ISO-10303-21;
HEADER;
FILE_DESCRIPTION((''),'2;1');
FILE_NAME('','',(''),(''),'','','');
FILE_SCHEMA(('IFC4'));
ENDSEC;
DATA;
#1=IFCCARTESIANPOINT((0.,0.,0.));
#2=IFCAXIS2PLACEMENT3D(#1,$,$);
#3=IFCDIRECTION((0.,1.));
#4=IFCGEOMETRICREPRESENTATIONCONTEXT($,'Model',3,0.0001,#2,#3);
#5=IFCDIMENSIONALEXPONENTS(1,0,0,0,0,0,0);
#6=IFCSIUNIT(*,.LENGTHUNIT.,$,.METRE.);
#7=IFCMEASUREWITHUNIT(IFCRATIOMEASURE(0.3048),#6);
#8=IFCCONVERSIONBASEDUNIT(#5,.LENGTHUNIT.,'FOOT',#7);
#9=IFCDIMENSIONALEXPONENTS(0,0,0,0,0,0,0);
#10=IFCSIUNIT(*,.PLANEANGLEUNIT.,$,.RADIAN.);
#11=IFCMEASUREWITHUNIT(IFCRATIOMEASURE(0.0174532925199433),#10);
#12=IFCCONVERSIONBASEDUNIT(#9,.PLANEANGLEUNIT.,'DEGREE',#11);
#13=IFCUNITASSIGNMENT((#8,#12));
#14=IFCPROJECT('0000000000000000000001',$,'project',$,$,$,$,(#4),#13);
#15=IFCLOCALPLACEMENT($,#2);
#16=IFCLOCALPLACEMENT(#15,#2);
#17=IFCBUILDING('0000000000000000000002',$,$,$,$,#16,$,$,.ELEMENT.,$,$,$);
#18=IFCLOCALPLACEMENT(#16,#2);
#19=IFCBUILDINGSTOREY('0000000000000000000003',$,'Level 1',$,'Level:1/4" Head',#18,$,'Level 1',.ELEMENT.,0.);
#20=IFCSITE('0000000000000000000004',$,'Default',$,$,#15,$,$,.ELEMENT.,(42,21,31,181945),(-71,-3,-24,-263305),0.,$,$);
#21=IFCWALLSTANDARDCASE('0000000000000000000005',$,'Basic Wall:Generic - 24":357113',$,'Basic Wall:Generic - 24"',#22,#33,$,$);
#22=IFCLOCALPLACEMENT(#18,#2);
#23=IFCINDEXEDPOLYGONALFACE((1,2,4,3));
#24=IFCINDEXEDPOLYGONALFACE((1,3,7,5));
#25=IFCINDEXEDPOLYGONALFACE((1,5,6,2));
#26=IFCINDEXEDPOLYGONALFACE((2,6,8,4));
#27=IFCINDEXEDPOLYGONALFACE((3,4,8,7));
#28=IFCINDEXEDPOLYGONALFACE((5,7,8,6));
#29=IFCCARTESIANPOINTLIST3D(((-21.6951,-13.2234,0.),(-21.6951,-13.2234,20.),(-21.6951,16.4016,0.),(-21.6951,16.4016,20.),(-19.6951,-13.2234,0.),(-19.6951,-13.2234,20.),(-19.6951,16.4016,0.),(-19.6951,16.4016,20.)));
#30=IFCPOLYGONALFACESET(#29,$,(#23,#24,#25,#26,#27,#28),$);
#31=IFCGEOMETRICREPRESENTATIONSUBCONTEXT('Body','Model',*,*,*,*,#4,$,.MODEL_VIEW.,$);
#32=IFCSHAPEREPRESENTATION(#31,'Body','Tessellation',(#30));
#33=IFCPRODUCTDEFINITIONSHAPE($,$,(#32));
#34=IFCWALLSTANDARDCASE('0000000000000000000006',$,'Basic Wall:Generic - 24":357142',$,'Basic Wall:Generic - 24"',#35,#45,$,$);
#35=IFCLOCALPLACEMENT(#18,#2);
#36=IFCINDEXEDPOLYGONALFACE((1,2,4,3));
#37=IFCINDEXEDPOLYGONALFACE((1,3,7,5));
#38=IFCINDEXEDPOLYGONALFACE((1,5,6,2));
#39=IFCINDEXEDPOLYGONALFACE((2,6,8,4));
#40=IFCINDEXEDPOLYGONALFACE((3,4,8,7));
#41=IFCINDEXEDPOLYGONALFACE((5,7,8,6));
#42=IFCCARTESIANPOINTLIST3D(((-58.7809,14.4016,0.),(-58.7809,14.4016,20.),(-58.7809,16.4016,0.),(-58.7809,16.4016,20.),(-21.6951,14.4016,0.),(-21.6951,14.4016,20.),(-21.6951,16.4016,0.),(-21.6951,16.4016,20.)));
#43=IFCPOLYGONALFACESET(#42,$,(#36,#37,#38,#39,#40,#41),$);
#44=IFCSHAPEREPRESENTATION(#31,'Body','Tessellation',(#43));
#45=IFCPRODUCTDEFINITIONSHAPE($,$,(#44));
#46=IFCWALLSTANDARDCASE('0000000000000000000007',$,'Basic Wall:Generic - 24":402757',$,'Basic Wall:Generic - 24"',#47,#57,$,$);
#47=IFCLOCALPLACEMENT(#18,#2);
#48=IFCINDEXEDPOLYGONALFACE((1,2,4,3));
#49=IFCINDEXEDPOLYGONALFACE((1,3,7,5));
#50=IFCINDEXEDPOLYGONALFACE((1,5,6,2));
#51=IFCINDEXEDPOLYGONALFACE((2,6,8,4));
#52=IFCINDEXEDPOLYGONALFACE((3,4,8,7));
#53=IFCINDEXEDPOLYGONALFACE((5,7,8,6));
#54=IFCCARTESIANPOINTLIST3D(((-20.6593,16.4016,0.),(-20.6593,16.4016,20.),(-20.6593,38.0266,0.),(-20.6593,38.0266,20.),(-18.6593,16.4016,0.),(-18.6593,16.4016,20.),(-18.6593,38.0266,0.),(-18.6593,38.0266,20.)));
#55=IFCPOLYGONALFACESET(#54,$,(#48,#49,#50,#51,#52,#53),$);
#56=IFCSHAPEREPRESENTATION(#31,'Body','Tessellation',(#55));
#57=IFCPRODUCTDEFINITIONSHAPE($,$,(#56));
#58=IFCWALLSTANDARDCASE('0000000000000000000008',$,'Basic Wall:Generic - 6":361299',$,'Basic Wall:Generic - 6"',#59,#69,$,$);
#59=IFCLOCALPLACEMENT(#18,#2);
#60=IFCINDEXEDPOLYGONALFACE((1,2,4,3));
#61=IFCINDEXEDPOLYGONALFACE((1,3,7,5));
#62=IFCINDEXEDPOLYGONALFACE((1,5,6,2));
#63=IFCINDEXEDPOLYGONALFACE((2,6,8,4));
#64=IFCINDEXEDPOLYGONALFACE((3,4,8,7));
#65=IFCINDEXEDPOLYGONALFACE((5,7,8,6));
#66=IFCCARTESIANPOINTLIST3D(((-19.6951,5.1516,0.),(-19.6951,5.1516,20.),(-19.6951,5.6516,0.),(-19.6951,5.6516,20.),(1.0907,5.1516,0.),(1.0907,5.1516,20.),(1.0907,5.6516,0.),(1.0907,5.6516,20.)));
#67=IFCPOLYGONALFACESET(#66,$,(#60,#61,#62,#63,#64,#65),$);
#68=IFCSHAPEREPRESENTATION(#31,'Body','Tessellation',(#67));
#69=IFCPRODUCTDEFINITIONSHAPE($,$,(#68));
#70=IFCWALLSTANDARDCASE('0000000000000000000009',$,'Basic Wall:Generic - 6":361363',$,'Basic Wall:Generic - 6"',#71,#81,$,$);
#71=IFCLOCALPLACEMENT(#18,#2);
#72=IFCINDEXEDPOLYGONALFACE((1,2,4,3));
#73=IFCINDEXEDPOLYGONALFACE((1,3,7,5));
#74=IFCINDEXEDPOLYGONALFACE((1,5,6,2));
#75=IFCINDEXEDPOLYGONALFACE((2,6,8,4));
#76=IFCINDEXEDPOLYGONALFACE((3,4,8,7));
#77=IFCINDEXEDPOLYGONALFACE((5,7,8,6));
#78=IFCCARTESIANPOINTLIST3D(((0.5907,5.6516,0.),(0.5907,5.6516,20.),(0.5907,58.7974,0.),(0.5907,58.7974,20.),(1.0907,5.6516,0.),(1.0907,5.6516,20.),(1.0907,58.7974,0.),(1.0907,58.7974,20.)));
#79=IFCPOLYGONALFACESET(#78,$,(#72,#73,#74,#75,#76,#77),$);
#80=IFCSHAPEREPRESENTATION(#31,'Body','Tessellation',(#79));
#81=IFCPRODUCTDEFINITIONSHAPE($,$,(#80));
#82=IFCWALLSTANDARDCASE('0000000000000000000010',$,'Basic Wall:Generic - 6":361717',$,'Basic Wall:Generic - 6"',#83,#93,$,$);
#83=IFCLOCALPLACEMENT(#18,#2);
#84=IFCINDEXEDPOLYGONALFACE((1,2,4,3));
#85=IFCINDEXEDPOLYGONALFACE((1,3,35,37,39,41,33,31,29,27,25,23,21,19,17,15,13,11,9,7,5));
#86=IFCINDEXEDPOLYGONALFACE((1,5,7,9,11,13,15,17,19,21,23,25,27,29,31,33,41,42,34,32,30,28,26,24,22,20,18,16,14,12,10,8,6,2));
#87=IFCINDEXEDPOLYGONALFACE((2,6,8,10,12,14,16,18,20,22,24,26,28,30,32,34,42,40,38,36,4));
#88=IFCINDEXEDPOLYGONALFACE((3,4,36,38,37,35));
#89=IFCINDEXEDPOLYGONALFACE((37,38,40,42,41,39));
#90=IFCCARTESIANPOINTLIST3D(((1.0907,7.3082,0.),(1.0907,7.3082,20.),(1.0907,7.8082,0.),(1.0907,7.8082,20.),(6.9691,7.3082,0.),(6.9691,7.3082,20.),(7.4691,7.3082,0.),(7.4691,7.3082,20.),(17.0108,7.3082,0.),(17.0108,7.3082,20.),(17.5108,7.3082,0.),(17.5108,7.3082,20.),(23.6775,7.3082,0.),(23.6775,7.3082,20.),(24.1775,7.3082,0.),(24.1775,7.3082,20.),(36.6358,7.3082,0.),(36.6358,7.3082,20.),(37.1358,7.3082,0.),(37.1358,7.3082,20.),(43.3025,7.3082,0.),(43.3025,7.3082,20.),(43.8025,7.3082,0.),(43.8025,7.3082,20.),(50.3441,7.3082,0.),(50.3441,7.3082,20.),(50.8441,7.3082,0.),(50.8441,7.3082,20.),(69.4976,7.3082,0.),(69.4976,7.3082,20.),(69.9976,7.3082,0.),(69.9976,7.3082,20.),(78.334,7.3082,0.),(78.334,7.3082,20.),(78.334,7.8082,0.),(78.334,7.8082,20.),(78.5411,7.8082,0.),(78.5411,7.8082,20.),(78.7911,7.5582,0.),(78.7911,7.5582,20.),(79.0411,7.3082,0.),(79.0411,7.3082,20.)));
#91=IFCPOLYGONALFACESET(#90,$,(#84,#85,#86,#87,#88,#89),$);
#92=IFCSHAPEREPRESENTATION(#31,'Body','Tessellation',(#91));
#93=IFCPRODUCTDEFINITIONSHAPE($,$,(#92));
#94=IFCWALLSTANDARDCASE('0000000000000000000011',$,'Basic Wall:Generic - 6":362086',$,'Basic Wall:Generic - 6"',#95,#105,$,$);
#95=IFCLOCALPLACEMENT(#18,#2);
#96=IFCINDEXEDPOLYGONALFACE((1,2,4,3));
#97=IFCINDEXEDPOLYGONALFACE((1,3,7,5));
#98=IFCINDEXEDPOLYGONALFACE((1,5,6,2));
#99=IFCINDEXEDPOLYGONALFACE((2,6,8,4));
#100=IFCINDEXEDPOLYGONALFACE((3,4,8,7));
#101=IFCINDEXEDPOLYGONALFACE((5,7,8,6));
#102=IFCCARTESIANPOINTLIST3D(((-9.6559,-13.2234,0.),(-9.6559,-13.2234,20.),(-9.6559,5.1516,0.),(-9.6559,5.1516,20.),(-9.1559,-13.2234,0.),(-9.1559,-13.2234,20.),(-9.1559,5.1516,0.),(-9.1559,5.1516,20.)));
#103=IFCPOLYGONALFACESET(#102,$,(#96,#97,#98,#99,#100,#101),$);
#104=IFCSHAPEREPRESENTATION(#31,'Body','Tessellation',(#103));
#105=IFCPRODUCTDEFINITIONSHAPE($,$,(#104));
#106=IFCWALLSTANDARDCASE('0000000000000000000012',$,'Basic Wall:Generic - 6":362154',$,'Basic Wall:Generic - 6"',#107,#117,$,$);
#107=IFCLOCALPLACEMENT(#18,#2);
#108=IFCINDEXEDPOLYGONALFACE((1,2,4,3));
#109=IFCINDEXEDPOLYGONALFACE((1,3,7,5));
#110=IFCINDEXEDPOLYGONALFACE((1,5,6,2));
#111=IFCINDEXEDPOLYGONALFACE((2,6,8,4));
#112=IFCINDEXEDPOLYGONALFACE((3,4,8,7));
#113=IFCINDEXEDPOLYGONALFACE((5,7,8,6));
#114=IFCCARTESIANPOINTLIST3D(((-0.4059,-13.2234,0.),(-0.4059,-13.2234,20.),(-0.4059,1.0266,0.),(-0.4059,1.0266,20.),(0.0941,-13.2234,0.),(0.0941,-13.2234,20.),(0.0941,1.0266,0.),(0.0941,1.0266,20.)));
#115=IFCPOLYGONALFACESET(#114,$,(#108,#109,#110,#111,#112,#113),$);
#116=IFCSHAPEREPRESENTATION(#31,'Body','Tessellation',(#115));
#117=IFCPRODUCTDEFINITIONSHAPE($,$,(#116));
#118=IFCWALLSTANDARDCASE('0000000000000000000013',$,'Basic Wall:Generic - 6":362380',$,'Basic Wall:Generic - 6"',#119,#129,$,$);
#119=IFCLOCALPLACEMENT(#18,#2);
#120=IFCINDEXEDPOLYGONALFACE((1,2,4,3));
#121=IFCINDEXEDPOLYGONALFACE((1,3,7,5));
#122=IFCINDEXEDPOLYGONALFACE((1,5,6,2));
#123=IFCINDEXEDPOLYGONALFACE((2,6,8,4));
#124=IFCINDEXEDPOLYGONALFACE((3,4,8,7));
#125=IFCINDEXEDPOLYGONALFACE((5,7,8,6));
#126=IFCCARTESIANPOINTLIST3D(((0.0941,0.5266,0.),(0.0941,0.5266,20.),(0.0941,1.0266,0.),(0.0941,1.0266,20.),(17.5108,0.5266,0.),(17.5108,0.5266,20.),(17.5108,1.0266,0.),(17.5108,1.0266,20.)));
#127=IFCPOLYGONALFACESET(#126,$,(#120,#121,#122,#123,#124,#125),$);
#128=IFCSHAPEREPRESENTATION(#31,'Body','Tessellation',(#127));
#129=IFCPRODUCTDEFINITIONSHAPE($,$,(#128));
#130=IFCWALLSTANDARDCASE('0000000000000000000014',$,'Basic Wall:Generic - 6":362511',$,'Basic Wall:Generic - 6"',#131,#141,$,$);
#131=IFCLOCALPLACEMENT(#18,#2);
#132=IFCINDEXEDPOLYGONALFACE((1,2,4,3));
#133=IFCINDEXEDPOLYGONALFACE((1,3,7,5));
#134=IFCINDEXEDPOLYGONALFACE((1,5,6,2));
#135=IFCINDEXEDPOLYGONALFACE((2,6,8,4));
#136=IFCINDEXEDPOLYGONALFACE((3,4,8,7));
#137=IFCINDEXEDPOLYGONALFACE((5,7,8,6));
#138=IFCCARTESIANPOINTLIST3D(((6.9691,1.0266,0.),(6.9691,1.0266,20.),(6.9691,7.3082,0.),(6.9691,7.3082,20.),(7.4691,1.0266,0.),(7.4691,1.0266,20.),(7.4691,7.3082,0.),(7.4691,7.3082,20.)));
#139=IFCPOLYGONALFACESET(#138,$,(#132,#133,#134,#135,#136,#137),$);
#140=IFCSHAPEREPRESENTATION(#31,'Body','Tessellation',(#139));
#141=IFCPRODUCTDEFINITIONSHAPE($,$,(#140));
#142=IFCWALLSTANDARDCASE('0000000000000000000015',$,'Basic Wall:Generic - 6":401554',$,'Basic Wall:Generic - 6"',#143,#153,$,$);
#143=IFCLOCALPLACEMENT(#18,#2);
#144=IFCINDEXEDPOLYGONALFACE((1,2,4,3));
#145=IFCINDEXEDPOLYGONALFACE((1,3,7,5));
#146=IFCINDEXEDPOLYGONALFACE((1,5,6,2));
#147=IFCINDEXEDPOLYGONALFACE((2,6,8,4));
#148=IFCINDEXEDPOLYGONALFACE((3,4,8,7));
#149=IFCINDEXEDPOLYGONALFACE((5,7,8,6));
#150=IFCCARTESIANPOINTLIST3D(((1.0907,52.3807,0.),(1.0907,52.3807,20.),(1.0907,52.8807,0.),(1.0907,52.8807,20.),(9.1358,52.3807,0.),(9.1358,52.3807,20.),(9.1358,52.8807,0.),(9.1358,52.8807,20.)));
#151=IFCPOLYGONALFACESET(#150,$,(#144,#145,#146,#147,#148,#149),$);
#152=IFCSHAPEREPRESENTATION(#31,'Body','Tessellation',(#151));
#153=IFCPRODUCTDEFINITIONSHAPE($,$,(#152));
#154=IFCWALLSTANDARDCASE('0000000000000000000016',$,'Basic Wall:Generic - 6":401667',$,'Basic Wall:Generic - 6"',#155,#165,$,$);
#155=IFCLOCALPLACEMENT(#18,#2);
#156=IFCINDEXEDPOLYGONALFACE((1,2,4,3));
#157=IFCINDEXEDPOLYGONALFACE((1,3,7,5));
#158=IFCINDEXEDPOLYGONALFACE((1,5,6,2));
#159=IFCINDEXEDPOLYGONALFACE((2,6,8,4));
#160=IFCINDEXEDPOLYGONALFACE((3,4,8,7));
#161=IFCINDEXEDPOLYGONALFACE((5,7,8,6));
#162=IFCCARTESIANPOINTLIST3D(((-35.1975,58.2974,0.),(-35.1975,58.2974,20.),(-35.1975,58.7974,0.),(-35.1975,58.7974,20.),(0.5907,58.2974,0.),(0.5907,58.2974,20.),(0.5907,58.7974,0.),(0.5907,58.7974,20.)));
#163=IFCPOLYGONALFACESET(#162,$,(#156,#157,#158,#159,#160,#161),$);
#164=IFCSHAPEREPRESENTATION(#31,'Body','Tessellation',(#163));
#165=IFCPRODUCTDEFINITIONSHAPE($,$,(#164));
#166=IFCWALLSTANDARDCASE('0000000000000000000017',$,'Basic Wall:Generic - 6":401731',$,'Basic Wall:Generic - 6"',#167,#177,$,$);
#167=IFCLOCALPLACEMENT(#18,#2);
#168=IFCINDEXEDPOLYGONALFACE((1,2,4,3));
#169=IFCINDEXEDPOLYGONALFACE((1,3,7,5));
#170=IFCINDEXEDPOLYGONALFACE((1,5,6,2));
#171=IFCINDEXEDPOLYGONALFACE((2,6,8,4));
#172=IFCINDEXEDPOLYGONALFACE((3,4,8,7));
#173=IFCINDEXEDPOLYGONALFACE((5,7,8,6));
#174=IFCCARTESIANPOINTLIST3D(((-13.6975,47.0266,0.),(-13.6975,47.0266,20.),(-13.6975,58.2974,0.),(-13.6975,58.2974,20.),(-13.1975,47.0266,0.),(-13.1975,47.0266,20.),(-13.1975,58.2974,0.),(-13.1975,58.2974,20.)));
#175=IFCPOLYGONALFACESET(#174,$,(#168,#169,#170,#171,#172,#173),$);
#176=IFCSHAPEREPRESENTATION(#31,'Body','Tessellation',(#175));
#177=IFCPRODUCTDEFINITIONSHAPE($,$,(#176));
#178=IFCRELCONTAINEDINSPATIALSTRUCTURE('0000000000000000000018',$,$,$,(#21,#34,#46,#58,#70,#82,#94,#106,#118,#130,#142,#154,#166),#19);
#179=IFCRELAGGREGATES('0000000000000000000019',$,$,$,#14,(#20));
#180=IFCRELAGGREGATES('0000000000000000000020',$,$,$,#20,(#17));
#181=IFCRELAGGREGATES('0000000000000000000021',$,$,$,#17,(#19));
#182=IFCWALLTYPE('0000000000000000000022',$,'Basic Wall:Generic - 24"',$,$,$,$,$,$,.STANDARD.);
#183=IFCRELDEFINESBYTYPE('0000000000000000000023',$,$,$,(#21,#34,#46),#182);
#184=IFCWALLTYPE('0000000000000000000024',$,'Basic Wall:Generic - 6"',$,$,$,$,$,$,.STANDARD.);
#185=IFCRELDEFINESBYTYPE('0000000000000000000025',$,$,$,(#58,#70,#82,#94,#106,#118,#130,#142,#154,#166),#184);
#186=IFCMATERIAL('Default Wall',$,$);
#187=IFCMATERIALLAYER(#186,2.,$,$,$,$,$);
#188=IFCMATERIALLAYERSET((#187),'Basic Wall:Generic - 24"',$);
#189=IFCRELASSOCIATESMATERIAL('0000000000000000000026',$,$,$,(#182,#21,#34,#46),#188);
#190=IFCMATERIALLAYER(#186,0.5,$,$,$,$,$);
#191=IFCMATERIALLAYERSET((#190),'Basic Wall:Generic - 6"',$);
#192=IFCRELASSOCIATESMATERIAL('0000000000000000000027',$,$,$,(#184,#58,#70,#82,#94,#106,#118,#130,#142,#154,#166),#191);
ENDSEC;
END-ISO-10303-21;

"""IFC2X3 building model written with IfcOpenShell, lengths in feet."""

from ifc_helpers import new_model, entity, si_unit, converted_unit, direction, frame, frame_2d, origin, place, context, subcontext, project, spatial, polyline, rectangle, outline, extrude, material, layer, layer_set, layer_usage, type_object, element, save


model = new_model("IFC2X3")

# Units and contexts
model_context = context("Model", 3, precision=0.0001, world=origin(), true_north=direction((0.0, 1.0)))
body_context = subcontext(model_context, "Body", "Model", "MODEL_VIEW")
ifc_project = project(units=[converted_unit("LENGTHUNIT", "FOOT", entity("IfcRatioMeasure", 0.3048), si_unit("LENGTHUNIT", "METRE"), dimensions=[1, 0, 0, 0, 0, 0, 0]), converted_unit("PLANEANGLEUNIT", "DEGREE", entity("IfcRatioMeasure", 0.0174532925199433), si_unit("PLANEANGLEUNIT", "RADIAN"), dimensions=[0, 0, 0, 0, 0, 0, 0])], contexts=[model_context])

# Site, building, storey
site_placement = place(None, origin())
site = spatial("IfcSite", under=ifc_project, at=site_placement, Name="Default", CompositionType="ELEMENT", RefLatitude=(42, 21, 31, 181945), RefLongitude=(-71, -3, -24, -263305), RefElevation=0.0)
building_placement = place(site_placement, origin())
building = spatial("IfcBuilding", under=site, at=building_placement, CompositionType="ELEMENT")
storey_placement = place(building_placement, origin())
storey = spatial("IfcBuildingStorey", under=building, at=storey_placement, Name="Level 1", ObjectType="Level:1/4\" Head", LongName="Level 1", CompositionType="ELEMENT", Elevation=0.0)

# Walls
ifc_material = material(Name="Default Wall")
ifc_layer_1 = layer(ifc_material, 2.0)
ifc_layer_set_1 = layer_set([ifc_layer_1], Name="Basic Wall:Generic - 24\"")
ifc_layer_usage_1 = layer_usage(ifc_layer_set_1, "AXIS2", "NEGATIVE", 1.0)
wall_type_1 = type_object("IfcWallType", Name="Basic Wall:Generic - 24\"", PredefinedType="STANDARD", material=ifc_layer_set_1)
wall_1_placement = place(storey_placement, frame((-20.6951, -13.2234, 0.0), z_axis=(0.0, 0.0, 1.0), x_axis=(0.0, 1.0, 0.0)))
element("IfcWallStandardCase", 1, at=wall_1_placement, inside=storey, type_object=wall_type_1, material=ifc_layer_usage_1, Name="Basic Wall:Generic - 24\":357113", ObjectType="Basic Wall:Generic - 24\"", context=body_context, shape_type="SweptSolid", body=[
    extrude(rectangle(XDim=29.625, YDim=2.0, at=frame_2d((14.8125, 0.0), x_axis=(-1.0, 0.0))), origin(), (0.0, 0.0, 1.0), 20.0),
])
ifc_layer_usage_2 = layer_usage(ifc_layer_set_1, "AXIS2", "NEGATIVE", 1.0)
wall_2_placement = place(storey_placement, frame((-21.6951, 15.4016, 0.0), z_axis=(0.0, 0.0, 1.0), x_axis=(-1.0, 0.0, 0.0)))
element("IfcWallStandardCase", 2, at=wall_2_placement, inside=storey, type_object=wall_type_1, material=ifc_layer_usage_2, Name="Basic Wall:Generic - 24\":357142", ObjectType="Basic Wall:Generic - 24\"", context=body_context, shape_type="SweptSolid", body=[
    extrude(rectangle(XDim=37.0858, YDim=2.0, at=frame_2d((18.5429, 0.0), x_axis=(-1.0, 0.0))), origin(), (0.0, 0.0, 1.0), 20.0),
])
ifc_layer_usage_3 = layer_usage(ifc_layer_set_1, "AXIS2", "NEGATIVE", 1.0)
wall_3_placement = place(storey_placement, frame((-19.6593, 38.0266, 0.0), z_axis=(0.0, 0.0, 1.0), x_axis=(0.0, -1.0, 0.0)))
element("IfcWallStandardCase", 3, at=wall_3_placement, inside=storey, type_object=wall_type_1, material=ifc_layer_usage_3, Name="Basic Wall:Generic - 24\":402757", ObjectType="Basic Wall:Generic - 24\"", context=body_context, shape_type="SweptSolid", body=[
    extrude(rectangle(XDim=21.625, YDim=2.0, at=frame_2d((10.8125, 0.0), x_axis=(-1.0, 0.0))), origin(), (0.0, 0.0, 1.0), 20.0),
])
ifc_layer_2 = layer(ifc_material, 0.5)
ifc_layer_set_2 = layer_set([ifc_layer_2], Name="Basic Wall:Generic - 6\"")
ifc_layer_usage_4 = layer_usage(ifc_layer_set_2, "AXIS2", "NEGATIVE", 0.25)
wall_type_2 = type_object("IfcWallType", Name="Basic Wall:Generic - 6\"", PredefinedType="STANDARD", material=ifc_layer_set_2)
wall_4_placement = place(storey_placement, frame((-19.6951, 5.4016, 0.0)))
element("IfcWallStandardCase", 4, at=wall_4_placement, inside=storey, type_object=wall_type_2, material=ifc_layer_usage_4, Name="Basic Wall:Generic - 6\":361299", ObjectType="Basic Wall:Generic - 6\"", context=body_context, shape_type="SweptSolid", body=[
    extrude(rectangle(XDim=20.7858, YDim=0.5, at=frame_2d((10.3929, 0.0), x_axis=(-1.0, 0.0))), origin(), (0.0, 0.0, 1.0), 20.0),
])
ifc_layer_usage_5 = layer_usage(ifc_layer_set_2, "AXIS2", "NEGATIVE", 0.25)
wall_5_placement = place(storey_placement, frame((0.8407, 5.6516, 0.0), z_axis=(0.0, 0.0, 1.0), x_axis=(0.0, 1.0, 0.0)))
element("IfcWallStandardCase", 5, at=wall_5_placement, inside=storey, type_object=wall_type_2, material=ifc_layer_usage_5, Name="Basic Wall:Generic - 6\":361363", ObjectType="Basic Wall:Generic - 6\"", context=body_context, shape_type="SweptSolid", body=[
    extrude(rectangle(XDim=53.1458, YDim=0.5, at=frame_2d((26.5729, 0.0), x_axis=(-1.0, 0.0))), origin(), (0.0, 0.0, 1.0), 20.0),
])
ifc_layer_usage_6 = layer_usage(ifc_layer_set_2, "AXIS2", "NEGATIVE", 0.25)
wall_6_placement = place(storey_placement, frame((1.0907, 7.5582, 0.0)))
element("IfcWallStandardCase", 6, at=wall_6_placement, inside=storey, type_object=wall_type_2, material=ifc_layer_usage_6, Name="Basic Wall:Generic - 6\":361717", ObjectType="Basic Wall:Generic - 6\"", context=body_context, shape_type="SweptSolid", body=[
    extrude(outline(polyline([(77.9504, -0.25), (77.7004, 0.0), (77.4504, 0.25), (77.2432, 0.25), (0.0, 0.25), (0.0, -0.25), (5.8784, -0.25), (6.3784, -0.25), (15.92, -0.25), (16.42, -0.25), (22.5867, -0.25), (23.0867, -0.25), (35.545, -0.25), (36.045, -0.25), (42.2117, -0.25), (42.7117, -0.25), (49.2534, -0.25), (49.7534, -0.25), (68.4069, -0.25), (68.9069, -0.25), (77.2432, -0.25), (77.9504, -0.25)])), origin(), (0.0, 0.0, 1.0), 20.0),
])
ifc_layer_usage_7 = layer_usage(ifc_layer_set_2, "AXIS2", "NEGATIVE", 0.25)
wall_7_placement = place(storey_placement, frame((-9.4059, -13.2234, 0.0), z_axis=(0.0, 0.0, 1.0), x_axis=(0.0, 1.0, 0.0)))
element("IfcWallStandardCase", 7, at=wall_7_placement, inside=storey, type_object=wall_type_2, material=ifc_layer_usage_7, Name="Basic Wall:Generic - 6\":362086", ObjectType="Basic Wall:Generic - 6\"", context=body_context, shape_type="SweptSolid", body=[
    extrude(rectangle(XDim=18.375, YDim=0.5, at=frame_2d((9.1875, 0.0), x_axis=(-1.0, 0.0))), origin(), (0.0, 0.0, 1.0), 20.0),
])
ifc_layer_usage_8 = layer_usage(ifc_layer_set_2, "AXIS2", "NEGATIVE", 0.25)
wall_8_placement = place(storey_placement, frame((-0.1559, -13.2234, 0.0), z_axis=(0.0, 0.0, 1.0), x_axis=(0.0, 1.0, 0.0)))
element("IfcWallStandardCase", 8, at=wall_8_placement, inside=storey, type_object=wall_type_2, material=ifc_layer_usage_8, Name="Basic Wall:Generic - 6\":362154", ObjectType="Basic Wall:Generic - 6\"", context=body_context, shape_type="SweptSolid", body=[
    extrude(rectangle(XDim=14.25, YDim=0.5, at=frame_2d((7.125, 0.0), x_axis=(-1.0, 0.0))), origin(), (0.0, 0.0, 1.0), 20.0),
])
ifc_layer_usage_9 = layer_usage(ifc_layer_set_2, "AXIS2", "NEGATIVE", 0.25)
wall_9_placement = place(storey_placement, frame((0.0941, 0.7766, 0.0)))
element("IfcWallStandardCase", 9, at=wall_9_placement, inside=storey, type_object=wall_type_2, material=ifc_layer_usage_9, Name="Basic Wall:Generic - 6\":362380", ObjectType="Basic Wall:Generic - 6\"", context=body_context, shape_type="SweptSolid", body=[
    extrude(rectangle(XDim=17.4167, YDim=0.5, at=frame_2d((8.7083, 0.0), x_axis=(-1.0, 0.0))), origin(), (0.0, 0.0, 1.0), 20.0),
])
ifc_layer_usage_10 = layer_usage(ifc_layer_set_2, "AXIS2", "NEGATIVE", 0.25)
wall_10_placement = place(storey_placement, frame((7.2191, 1.0266, 0.0), z_axis=(0.0, 0.0, 1.0), x_axis=(0.0, 1.0, 0.0)))
element("IfcWallStandardCase", 10, at=wall_10_placement, inside=storey, type_object=wall_type_2, material=ifc_layer_usage_10, Name="Basic Wall:Generic - 6\":362511", ObjectType="Basic Wall:Generic - 6\"", context=body_context, shape_type="SweptSolid", body=[
    extrude(rectangle(XDim=6.2816, YDim=0.5, at=frame_2d((3.1408, 0.0), x_axis=(-1.0, 0.0))), origin(), (0.0, 0.0, 1.0), 20.0),
])
ifc_layer_usage_11 = layer_usage(ifc_layer_set_2, "AXIS2", "NEGATIVE", 0.25)
wall_11_placement = place(storey_placement, frame((1.0907, 52.6307, 0.0)))
element("IfcWallStandardCase", 11, at=wall_11_placement, inside=storey, type_object=wall_type_2, material=ifc_layer_usage_11, Name="Basic Wall:Generic - 6\":401554", ObjectType="Basic Wall:Generic - 6\"", context=body_context, shape_type="SweptSolid", body=[
    extrude(rectangle(XDim=8.045, YDim=0.5, at=frame_2d((4.0225, 0.0), x_axis=(-1.0, 0.0))), origin(), (0.0, 0.0, 1.0), 20.0),
])
ifc_layer_usage_12 = layer_usage(ifc_layer_set_2, "AXIS2", "NEGATIVE", 0.25)
wall_12_placement = place(storey_placement, frame((0.5907, 58.5474, 0.0), z_axis=(0.0, 0.0, 1.0), x_axis=(-1.0, 0.0, 0.0)))
element("IfcWallStandardCase", 12, at=wall_12_placement, inside=storey, type_object=wall_type_2, material=ifc_layer_usage_12, Name="Basic Wall:Generic - 6\":401667", ObjectType="Basic Wall:Generic - 6\"", context=body_context, shape_type="SweptSolid", body=[
    extrude(rectangle(XDim=35.7883, YDim=0.5, at=frame_2d((17.8941, 0.0), x_axis=(-1.0, 0.0))), origin(), (0.0, 0.0, 1.0), 20.0),
])
ifc_layer_usage_13 = layer_usage(ifc_layer_set_2, "AXIS2", "NEGATIVE", 0.25)
wall_13_placement = place(storey_placement, frame((-13.4475, 58.2974, 0.0), z_axis=(0.0, 0.0, 1.0), x_axis=(0.0, -1.0, 0.0)))
element("IfcWallStandardCase", 13, at=wall_13_placement, inside=storey, type_object=wall_type_2, material=ifc_layer_usage_13, Name="Basic Wall:Generic - 6\":401731", ObjectType="Basic Wall:Generic - 6\"", context=body_context, shape_type="SweptSolid", body=[
    extrude(rectangle(XDim=11.2708, YDim=0.5, at=frame_2d((5.6354, 0.0), x_axis=(-1.0, 0.0))), origin(), (0.0, 0.0, 1.0), 20.0),
])

save(model, "model.ifc")
